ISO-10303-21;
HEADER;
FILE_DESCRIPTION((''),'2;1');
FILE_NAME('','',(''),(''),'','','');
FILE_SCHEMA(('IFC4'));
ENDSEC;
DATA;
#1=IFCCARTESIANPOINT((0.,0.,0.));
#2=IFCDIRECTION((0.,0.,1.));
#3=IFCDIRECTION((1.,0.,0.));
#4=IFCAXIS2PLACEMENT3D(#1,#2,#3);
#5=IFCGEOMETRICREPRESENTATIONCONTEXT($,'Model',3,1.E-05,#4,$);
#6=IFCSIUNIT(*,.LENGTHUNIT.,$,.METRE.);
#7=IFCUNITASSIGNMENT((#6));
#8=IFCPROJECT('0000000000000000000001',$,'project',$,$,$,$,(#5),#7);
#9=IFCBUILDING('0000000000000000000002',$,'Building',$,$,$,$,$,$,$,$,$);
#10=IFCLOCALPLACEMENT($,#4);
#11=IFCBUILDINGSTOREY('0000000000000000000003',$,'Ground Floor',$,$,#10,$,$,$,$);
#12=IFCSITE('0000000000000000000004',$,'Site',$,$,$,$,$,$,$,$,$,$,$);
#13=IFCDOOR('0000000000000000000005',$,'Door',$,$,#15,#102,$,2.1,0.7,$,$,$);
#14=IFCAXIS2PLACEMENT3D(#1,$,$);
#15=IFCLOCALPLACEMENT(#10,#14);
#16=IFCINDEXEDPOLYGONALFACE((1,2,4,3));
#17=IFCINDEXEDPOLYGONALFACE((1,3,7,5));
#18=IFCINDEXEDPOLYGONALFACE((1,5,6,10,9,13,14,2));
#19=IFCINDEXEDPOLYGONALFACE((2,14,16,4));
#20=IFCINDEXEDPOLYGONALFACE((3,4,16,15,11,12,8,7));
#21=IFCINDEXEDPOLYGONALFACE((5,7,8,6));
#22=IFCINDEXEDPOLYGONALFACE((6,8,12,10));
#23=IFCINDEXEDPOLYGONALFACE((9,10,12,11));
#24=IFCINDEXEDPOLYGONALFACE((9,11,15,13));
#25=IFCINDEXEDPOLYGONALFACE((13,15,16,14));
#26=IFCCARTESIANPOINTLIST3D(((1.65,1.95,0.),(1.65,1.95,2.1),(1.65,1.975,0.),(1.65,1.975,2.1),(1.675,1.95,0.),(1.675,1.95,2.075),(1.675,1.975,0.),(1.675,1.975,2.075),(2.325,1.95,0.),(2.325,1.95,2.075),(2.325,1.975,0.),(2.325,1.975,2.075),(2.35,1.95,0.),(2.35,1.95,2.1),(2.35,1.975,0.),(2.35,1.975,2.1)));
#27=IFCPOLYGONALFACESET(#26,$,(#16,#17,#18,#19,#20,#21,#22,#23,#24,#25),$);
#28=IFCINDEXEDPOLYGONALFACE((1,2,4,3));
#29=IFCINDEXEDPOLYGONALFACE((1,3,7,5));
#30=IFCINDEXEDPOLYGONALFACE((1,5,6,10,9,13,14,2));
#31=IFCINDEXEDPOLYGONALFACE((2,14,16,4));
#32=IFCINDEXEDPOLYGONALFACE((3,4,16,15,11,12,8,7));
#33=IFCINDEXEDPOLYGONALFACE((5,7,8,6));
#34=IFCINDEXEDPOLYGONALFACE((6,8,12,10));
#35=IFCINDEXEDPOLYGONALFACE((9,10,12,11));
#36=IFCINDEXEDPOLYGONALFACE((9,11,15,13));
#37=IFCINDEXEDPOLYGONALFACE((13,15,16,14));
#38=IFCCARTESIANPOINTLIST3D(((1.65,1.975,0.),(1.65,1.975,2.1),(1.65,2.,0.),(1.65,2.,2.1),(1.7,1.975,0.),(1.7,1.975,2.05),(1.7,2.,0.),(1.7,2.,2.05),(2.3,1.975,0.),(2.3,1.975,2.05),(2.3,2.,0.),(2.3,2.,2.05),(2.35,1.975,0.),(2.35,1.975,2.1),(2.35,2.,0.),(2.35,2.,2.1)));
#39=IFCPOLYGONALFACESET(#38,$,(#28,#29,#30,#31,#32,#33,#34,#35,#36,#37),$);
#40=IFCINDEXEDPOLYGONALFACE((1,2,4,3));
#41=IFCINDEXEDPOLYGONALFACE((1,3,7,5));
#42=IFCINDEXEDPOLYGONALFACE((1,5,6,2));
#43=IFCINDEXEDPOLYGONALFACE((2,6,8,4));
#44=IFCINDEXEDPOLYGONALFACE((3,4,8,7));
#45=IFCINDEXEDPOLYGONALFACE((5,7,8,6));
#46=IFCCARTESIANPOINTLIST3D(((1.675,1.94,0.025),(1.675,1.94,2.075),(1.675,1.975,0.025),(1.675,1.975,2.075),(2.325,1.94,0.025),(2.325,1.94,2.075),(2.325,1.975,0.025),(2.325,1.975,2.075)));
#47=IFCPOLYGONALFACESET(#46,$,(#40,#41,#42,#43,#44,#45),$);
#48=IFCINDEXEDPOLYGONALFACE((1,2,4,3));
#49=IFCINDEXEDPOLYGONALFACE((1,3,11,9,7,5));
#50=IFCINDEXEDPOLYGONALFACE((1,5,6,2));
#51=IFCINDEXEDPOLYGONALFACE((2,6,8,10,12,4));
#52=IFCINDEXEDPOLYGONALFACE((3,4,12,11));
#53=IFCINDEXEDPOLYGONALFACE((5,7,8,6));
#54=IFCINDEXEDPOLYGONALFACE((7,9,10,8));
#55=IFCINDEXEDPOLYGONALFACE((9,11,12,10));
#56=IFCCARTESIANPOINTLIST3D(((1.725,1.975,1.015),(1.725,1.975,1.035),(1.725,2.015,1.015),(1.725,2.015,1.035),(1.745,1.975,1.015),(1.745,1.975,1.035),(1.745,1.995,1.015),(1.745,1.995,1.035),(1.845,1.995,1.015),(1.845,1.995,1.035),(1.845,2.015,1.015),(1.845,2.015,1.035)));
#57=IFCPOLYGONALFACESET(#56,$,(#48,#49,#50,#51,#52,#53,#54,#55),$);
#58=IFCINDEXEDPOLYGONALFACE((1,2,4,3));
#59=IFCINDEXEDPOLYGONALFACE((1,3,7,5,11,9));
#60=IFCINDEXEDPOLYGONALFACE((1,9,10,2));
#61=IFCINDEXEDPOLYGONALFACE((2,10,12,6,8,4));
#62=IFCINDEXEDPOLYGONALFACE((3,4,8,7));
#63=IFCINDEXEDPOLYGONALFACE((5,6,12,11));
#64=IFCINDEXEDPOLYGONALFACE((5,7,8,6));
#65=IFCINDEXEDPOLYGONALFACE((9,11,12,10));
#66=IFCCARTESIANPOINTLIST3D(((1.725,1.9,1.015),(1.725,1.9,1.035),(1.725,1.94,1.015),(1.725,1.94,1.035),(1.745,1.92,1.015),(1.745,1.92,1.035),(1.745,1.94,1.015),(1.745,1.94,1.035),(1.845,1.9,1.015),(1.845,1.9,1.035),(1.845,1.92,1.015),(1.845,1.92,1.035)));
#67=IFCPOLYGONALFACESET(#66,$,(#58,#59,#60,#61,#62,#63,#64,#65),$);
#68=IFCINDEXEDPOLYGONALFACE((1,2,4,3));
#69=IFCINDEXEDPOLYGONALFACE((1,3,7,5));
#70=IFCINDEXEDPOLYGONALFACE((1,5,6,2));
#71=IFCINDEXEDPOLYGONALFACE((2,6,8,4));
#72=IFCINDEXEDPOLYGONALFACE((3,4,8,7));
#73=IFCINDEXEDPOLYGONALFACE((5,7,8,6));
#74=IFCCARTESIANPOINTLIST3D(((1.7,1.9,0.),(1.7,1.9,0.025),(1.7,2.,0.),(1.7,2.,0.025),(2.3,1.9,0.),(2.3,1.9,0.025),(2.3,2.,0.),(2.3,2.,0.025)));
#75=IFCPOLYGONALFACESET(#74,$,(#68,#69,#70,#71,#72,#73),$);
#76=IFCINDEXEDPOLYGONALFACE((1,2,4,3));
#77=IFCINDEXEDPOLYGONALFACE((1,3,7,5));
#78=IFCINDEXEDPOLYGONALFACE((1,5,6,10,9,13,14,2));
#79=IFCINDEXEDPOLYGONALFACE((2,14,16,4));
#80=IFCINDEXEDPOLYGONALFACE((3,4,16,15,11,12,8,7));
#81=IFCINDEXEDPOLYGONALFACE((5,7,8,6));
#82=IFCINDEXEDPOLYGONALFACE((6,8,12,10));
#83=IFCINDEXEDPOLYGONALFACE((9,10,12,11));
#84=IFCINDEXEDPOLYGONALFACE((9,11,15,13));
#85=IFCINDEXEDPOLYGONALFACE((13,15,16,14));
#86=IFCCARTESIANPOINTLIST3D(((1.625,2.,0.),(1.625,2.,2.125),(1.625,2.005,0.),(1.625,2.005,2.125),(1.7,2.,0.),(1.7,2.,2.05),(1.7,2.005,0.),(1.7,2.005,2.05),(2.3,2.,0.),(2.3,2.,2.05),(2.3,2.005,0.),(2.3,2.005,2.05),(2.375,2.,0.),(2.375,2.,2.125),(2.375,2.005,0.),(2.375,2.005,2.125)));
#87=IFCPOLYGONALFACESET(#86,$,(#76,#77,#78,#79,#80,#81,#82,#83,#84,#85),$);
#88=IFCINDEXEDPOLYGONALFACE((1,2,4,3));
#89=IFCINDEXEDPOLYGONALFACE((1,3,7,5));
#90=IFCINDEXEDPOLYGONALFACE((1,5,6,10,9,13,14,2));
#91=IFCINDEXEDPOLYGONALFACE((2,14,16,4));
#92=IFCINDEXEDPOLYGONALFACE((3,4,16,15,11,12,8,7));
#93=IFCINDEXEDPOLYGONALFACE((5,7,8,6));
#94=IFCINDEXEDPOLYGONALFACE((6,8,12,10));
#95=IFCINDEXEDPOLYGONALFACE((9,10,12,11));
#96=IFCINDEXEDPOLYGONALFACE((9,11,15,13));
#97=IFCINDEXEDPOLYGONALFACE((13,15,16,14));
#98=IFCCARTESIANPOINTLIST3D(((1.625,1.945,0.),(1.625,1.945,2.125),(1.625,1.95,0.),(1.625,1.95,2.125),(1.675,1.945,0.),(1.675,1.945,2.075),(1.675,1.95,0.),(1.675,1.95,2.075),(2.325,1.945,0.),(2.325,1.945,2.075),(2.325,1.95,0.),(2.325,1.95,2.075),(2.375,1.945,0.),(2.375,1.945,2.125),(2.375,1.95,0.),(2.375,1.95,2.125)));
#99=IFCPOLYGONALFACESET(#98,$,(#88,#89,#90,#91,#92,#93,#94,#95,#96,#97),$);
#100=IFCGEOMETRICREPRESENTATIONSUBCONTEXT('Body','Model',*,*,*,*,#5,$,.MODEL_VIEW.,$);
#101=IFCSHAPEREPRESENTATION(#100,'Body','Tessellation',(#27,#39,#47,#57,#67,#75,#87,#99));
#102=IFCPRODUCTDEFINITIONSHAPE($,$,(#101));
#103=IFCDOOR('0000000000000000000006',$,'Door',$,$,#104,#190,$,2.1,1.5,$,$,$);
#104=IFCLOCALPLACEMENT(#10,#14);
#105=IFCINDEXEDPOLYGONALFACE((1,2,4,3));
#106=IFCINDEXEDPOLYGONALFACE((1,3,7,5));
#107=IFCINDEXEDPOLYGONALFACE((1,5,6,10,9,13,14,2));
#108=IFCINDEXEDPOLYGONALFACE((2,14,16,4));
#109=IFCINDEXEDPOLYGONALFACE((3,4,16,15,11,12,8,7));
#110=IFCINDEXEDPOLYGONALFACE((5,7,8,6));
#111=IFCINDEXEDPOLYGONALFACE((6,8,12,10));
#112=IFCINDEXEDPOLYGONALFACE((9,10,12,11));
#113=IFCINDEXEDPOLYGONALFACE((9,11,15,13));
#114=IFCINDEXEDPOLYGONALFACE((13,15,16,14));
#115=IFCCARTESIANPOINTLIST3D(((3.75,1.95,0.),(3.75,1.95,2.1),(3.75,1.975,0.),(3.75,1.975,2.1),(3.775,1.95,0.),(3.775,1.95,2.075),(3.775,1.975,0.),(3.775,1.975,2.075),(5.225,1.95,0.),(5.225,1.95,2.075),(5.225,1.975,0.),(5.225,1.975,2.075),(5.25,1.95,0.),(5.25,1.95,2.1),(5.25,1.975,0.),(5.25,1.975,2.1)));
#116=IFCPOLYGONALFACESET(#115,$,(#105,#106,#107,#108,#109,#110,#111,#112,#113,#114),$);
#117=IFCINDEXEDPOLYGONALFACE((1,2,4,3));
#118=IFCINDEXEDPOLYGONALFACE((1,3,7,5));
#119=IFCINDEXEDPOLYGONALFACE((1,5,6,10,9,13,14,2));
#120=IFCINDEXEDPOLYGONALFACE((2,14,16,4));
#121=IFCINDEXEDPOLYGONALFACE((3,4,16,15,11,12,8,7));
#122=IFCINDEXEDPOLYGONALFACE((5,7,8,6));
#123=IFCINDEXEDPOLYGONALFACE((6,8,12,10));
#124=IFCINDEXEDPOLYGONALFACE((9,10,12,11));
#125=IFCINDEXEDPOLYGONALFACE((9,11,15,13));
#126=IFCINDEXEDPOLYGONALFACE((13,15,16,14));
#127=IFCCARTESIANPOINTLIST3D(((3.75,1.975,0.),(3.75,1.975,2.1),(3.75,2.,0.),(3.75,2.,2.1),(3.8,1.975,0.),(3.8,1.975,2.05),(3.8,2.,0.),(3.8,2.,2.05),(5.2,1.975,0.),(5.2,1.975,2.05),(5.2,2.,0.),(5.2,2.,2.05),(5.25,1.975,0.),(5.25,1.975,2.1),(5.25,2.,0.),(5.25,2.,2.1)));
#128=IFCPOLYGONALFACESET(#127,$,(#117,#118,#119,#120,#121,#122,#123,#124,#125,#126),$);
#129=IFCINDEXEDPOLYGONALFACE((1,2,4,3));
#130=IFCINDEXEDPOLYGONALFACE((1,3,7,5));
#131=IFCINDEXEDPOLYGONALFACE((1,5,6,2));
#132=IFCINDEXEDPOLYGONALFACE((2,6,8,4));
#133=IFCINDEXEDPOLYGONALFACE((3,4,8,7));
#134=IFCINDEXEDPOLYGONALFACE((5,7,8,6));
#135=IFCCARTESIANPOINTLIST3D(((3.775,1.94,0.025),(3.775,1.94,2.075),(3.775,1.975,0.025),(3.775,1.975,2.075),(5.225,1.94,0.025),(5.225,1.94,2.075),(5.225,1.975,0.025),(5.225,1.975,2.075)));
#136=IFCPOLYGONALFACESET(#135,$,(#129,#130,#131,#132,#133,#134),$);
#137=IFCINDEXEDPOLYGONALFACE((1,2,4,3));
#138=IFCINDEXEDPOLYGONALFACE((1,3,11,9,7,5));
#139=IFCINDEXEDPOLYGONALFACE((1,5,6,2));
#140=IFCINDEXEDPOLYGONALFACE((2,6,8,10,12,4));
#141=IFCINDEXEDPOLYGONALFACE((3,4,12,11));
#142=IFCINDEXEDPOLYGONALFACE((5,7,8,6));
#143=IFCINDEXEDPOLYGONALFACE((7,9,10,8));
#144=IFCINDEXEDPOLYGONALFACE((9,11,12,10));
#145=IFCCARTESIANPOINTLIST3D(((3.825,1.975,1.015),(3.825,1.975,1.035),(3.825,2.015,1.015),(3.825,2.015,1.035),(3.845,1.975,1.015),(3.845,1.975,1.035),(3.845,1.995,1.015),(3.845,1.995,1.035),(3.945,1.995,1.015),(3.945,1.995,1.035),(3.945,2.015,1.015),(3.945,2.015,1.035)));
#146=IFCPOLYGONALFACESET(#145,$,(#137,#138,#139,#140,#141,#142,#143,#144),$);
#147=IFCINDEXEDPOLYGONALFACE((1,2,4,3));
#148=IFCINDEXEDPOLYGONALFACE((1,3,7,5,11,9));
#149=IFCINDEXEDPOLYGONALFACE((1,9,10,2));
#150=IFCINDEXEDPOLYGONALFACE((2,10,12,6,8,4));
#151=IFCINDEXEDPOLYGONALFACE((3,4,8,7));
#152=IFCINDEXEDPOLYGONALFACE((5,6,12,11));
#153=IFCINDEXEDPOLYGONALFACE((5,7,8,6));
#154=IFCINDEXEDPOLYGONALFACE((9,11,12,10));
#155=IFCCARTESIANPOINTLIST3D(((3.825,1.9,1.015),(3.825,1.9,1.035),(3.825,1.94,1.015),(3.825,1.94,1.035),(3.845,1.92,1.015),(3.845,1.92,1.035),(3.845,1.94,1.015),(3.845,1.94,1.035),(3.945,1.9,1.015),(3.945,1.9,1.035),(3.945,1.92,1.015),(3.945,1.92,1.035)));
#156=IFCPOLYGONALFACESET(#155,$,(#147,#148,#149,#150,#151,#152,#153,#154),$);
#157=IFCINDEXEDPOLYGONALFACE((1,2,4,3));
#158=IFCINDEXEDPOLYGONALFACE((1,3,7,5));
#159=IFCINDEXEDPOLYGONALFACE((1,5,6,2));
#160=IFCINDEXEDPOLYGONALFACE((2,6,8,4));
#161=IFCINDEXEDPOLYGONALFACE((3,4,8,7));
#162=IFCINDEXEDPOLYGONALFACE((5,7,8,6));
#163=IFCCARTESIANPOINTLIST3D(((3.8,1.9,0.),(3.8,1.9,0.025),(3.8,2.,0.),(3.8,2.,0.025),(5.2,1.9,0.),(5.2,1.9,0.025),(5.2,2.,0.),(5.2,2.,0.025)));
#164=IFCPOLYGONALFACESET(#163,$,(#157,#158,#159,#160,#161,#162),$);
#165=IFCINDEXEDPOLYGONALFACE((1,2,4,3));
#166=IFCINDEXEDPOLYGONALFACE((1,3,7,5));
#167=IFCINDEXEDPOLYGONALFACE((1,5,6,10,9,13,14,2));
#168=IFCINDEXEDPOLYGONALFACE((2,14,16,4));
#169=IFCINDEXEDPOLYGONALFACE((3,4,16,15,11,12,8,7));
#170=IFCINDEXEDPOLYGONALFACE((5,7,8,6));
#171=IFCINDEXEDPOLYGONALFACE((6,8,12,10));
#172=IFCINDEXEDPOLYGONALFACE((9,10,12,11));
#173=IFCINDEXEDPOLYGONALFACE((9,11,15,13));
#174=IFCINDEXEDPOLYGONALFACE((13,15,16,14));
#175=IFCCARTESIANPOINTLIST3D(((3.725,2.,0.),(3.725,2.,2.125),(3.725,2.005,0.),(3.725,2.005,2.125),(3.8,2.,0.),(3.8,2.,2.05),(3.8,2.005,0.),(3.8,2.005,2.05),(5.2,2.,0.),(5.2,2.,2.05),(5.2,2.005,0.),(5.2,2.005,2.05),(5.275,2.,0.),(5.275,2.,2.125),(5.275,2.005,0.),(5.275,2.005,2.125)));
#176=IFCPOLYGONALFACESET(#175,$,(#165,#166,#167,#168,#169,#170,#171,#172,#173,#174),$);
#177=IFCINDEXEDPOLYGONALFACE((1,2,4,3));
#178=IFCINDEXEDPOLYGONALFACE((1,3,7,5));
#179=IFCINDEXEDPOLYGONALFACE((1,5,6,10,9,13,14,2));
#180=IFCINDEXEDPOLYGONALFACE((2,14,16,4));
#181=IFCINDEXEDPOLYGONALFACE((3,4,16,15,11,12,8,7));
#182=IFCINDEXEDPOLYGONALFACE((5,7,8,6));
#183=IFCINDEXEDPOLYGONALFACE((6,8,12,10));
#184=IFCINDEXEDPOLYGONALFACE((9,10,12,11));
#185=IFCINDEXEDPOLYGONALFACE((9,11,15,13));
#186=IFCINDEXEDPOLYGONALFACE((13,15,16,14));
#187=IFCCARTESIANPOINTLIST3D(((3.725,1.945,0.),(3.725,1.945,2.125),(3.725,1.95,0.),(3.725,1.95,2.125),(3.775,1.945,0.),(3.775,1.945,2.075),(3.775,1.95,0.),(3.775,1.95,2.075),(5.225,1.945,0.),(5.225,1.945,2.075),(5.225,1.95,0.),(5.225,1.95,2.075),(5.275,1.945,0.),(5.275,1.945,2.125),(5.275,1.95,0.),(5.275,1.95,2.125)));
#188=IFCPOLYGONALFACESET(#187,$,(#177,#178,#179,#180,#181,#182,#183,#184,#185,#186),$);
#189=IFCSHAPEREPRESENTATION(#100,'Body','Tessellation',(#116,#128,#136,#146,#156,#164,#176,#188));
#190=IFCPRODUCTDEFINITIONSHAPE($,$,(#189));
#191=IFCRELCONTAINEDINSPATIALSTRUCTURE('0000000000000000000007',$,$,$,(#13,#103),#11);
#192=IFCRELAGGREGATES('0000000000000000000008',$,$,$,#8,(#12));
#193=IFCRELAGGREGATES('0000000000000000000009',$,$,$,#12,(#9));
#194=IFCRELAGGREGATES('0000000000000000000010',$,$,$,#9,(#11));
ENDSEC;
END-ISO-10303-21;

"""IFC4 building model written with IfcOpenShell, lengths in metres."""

from ifc_helpers import new_model, si_unit, frame, origin_with_axes, place, context, subcontext, project, spatial, line, indexed_curve, outline, extrude, element, save


model = new_model("IFC4")

# Units and contexts
model_context = context("Model", 3, precision=1e-05, world=origin_with_axes())
body_context = subcontext(model_context, "Body", "Model", "MODEL_VIEW")
ifc_project = project(units=[si_unit("LENGTHUNIT", "METRE")], contexts=[model_context])

# Site, building, storey
site = spatial("IfcSite", under=ifc_project, Name="Site")
building = spatial("IfcBuilding", under=site, Name="Building")
storey_placement = place(None, origin_with_axes())
storey = spatial("IfcBuildingStorey", under=building, at=storey_placement, Name="Ground Floor")

# Doors
door_1_placement = place(storey_placement, frame((2.35, 2.0, 0.0), z_axis=(0.0, 0.0, 1.0), x_axis=(-1.0, 0.0, 0.0)))
element("IfcDoor", 1, at=door_1_placement, inside=storey, Name="Door", OverallHeight=2.1, OverallWidth=0.7, context=body_context, shape_type="SweptSolid", body=[
    extrude(outline(indexed_curve([(0.0, 0.0), (0.0, 2.1), (0.7, 2.1), (0.7, 0.0), (0.675, 0.0), (0.675, 2.075), (0.025, 2.075), (0.025, 0.0)], segments=[line(1, 2, 3, 4, 5, 6, 7, 8, 1)])), frame((0.0, 0.025, 0.0), z_axis=(0.0, -1.0, 0.0), x_axis=(1.0, 0.0, 0.0)), (0.0, 0.0, -1.0), 0.025),
    extrude(outline(indexed_curve([(0.0, 0.0), (0.0, 2.1), (0.7, 2.1), (0.7, 0.0), (0.65, 0.0), (0.65, 2.05), (0.05, 2.05), (0.05, 0.0)], segments=[line(1, 2, 3, 4, 5, 6, 7, 8, 1)])), frame((0.0, 0.0, 0.0), z_axis=(0.0, -1.0, 0.0), x_axis=(1.0, 0.0, 0.0)), (0.0, 0.0, -1.0), 0.025),
    extrude(outline(indexed_curve([(0.0, 0.0), (0.65, 0.0), (0.65, 0.035), (0.0, 0.035)], segments=[line(1, 2, 3, 4, 1)])), frame((0.025, 0.025, 0.025), z_axis=(0.0, 0.0, 1.0), x_axis=(1.0, 0.0, 0.0)), (0.0, 0.0, 1.0), 2.05),
    extrude(outline(indexed_curve([(0.0, 0.0), (0.0, -0.04), (-0.12, -0.04), (-0.12, -0.02), (-0.02, -0.02), (-0.02, 0.0)], segments=[line(1, 2, 3, 4, 5, 6, 1)])), frame((0.625, 0.025, 1.015), z_axis=(0.0, 0.0, 1.0), x_axis=(1.0, 0.0, 0.0)), (0.0, 0.0, 1.0), 0.02),
    extrude(outline(indexed_curve([(0.0, 0.0), (0.0, 0.04), (-0.12, 0.04), (-0.12, 0.02), (-0.02, 0.02), (-0.02, 0.0)], segments=[line(1, 2, 3, 4, 5, 6, 1)])), frame((0.625, 0.06, 1.015), z_axis=(0.0, 0.0, 1.0), x_axis=(1.0, 0.0, 0.0)), (0.0, 0.0, 1.0), 0.02),
    extrude(outline(indexed_curve([(0.0, 0.0), (0.6, 0.0), (0.6, 0.1), (0.0, 0.1)], segments=[line(1, 2, 3, 4, 1)])), frame((0.05, 0.0, 0.0), z_axis=(0.0, 0.0, 1.0), x_axis=(1.0, 0.0, 0.0)), (0.0, 0.0, 1.0), 0.025),
    extrude(outline(indexed_curve([(0.0, 0.0), (0.0, 2.125), (0.75, 2.125), (0.75, 0.0), (0.675, 0.0), (0.675, 2.05), (0.075, 2.05), (0.075, 0.0)], segments=[line(1, 2, 3, 4, 5, 6, 7, 8, 1)])), frame((-0.025, -0.005, 0.0), z_axis=(0.0, -1.0, 0.0), x_axis=(1.0, 0.0, 0.0)), (0.0, 0.0, -1.0), 0.005),
    extrude(outline(indexed_curve([(0.0, 0.0), (0.0, 2.125), (0.75, 2.125), (0.75, 0.0), (0.7, 0.0), (0.7, 2.075), (0.05, 2.075), (0.05, 0.0)], segments=[line(1, 2, 3, 4, 5, 6, 7, 8, 1)])), frame((-0.025, 0.05, 0.0), z_axis=(0.0, -1.0, 0.0), x_axis=(1.0, 0.0, 0.0)), (0.0, 0.0, -1.0), 0.005),
])
door_2_placement = place(storey_placement, frame((5.25, 2.0, 0.0), z_axis=(0.0, 0.0, 1.0), x_axis=(-1.0, 0.0, 0.0)))
element("IfcDoor", 2, at=door_2_placement, inside=storey, Name="Door", OverallHeight=2.1, OverallWidth=1.5, context=body_context, shape_type="SweptSolid", body=[
    extrude(outline(indexed_curve([(0.0, 0.0), (0.0, 2.1), (1.5, 2.1), (1.5, 0.0), (1.475, 0.0), (1.475, 2.075), (0.025, 2.075), (0.025, 0.0)], segments=[line(1, 2, 3, 4, 5, 6, 7, 8, 1)])), frame((0.0, 0.025, 0.0), z_axis=(0.0, -1.0, 0.0), x_axis=(1.0, 0.0, 0.0)), (0.0, 0.0, -1.0), 0.025),
    extrude(outline(indexed_curve([(0.0, 0.0), (0.0, 2.1), (1.5, 2.1), (1.5, 0.0), (1.45, 0.0), (1.45, 2.05), (0.05, 2.05), (0.05, 0.0)], segments=[line(1, 2, 3, 4, 5, 6, 7, 8, 1)])), frame((0.0, 0.0, 0.0), z_axis=(0.0, -1.0, 0.0), x_axis=(1.0, 0.0, 0.0)), (0.0, 0.0, -1.0), 0.025),
    extrude(outline(indexed_curve([(0.0, 0.0), (1.45, 0.0), (1.45, 0.035), (0.0, 0.035)], segments=[line(1, 2, 3, 4, 1)])), frame((0.025, 0.025, 0.025), z_axis=(0.0, 0.0, 1.0), x_axis=(1.0, 0.0, 0.0)), (0.0, 0.0, 1.0), 2.05),
    extrude(outline(indexed_curve([(0.0, 0.0), (0.0, -0.04), (-0.12, -0.04), (-0.12, -0.02), (-0.02, -0.02), (-0.02, 0.0)], segments=[line(1, 2, 3, 4, 5, 6, 1)])), frame((1.425, 0.025, 1.015), z_axis=(0.0, 0.0, 1.0), x_axis=(1.0, 0.0, 0.0)), (0.0, 0.0, 1.0), 0.02),
    extrude(outline(indexed_curve([(0.0, 0.0), (0.0, 0.04), (-0.12, 0.04), (-0.12, 0.02), (-0.02, 0.02), (-0.02, 0.0)], segments=[line(1, 2, 3, 4, 5, 6, 1)])), frame((1.425, 0.06, 1.015), z_axis=(0.0, 0.0, 1.0), x_axis=(1.0, 0.0, 0.0)), (0.0, 0.0, 1.0), 0.02),
    extrude(outline(indexed_curve([(0.0, 0.0), (1.4, 0.0), (1.4, 0.1), (0.0, 0.1)], segments=[line(1, 2, 3, 4, 1)])), frame((0.05, 0.0, 0.0), z_axis=(0.0, 0.0, 1.0), x_axis=(1.0, 0.0, 0.0)), (0.0, 0.0, 1.0), 0.025),
    extrude(outline(indexed_curve([(0.0, 0.0), (0.0, 2.125), (1.55, 2.125), (1.55, 0.0), (1.475, 0.0), (1.475, 2.05), (0.075, 2.05), (0.075, 0.0)], segments=[line(1, 2, 3, 4, 5, 6, 7, 8, 1)])), frame((-0.025, -0.005, 0.0), z_axis=(0.0, -1.0, 0.0), x_axis=(1.0, 0.0, 0.0)), (0.0, 0.0, -1.0), 0.005),
    extrude(outline(indexed_curve([(0.0, 0.0), (0.0, 2.125), (1.55, 2.125), (1.55, 0.0), (1.5, 0.0), (1.5, 2.075), (0.05, 2.075), (0.05, 0.0)], segments=[line(1, 2, 3, 4, 5, 6, 7, 8, 1)])), frame((-0.025, 0.05, 0.0), z_axis=(0.0, -1.0, 0.0), x_axis=(1.0, 0.0, 0.0)), (0.0, 0.0, -1.0), 0.005),
])

save(model, "model.ifc")
